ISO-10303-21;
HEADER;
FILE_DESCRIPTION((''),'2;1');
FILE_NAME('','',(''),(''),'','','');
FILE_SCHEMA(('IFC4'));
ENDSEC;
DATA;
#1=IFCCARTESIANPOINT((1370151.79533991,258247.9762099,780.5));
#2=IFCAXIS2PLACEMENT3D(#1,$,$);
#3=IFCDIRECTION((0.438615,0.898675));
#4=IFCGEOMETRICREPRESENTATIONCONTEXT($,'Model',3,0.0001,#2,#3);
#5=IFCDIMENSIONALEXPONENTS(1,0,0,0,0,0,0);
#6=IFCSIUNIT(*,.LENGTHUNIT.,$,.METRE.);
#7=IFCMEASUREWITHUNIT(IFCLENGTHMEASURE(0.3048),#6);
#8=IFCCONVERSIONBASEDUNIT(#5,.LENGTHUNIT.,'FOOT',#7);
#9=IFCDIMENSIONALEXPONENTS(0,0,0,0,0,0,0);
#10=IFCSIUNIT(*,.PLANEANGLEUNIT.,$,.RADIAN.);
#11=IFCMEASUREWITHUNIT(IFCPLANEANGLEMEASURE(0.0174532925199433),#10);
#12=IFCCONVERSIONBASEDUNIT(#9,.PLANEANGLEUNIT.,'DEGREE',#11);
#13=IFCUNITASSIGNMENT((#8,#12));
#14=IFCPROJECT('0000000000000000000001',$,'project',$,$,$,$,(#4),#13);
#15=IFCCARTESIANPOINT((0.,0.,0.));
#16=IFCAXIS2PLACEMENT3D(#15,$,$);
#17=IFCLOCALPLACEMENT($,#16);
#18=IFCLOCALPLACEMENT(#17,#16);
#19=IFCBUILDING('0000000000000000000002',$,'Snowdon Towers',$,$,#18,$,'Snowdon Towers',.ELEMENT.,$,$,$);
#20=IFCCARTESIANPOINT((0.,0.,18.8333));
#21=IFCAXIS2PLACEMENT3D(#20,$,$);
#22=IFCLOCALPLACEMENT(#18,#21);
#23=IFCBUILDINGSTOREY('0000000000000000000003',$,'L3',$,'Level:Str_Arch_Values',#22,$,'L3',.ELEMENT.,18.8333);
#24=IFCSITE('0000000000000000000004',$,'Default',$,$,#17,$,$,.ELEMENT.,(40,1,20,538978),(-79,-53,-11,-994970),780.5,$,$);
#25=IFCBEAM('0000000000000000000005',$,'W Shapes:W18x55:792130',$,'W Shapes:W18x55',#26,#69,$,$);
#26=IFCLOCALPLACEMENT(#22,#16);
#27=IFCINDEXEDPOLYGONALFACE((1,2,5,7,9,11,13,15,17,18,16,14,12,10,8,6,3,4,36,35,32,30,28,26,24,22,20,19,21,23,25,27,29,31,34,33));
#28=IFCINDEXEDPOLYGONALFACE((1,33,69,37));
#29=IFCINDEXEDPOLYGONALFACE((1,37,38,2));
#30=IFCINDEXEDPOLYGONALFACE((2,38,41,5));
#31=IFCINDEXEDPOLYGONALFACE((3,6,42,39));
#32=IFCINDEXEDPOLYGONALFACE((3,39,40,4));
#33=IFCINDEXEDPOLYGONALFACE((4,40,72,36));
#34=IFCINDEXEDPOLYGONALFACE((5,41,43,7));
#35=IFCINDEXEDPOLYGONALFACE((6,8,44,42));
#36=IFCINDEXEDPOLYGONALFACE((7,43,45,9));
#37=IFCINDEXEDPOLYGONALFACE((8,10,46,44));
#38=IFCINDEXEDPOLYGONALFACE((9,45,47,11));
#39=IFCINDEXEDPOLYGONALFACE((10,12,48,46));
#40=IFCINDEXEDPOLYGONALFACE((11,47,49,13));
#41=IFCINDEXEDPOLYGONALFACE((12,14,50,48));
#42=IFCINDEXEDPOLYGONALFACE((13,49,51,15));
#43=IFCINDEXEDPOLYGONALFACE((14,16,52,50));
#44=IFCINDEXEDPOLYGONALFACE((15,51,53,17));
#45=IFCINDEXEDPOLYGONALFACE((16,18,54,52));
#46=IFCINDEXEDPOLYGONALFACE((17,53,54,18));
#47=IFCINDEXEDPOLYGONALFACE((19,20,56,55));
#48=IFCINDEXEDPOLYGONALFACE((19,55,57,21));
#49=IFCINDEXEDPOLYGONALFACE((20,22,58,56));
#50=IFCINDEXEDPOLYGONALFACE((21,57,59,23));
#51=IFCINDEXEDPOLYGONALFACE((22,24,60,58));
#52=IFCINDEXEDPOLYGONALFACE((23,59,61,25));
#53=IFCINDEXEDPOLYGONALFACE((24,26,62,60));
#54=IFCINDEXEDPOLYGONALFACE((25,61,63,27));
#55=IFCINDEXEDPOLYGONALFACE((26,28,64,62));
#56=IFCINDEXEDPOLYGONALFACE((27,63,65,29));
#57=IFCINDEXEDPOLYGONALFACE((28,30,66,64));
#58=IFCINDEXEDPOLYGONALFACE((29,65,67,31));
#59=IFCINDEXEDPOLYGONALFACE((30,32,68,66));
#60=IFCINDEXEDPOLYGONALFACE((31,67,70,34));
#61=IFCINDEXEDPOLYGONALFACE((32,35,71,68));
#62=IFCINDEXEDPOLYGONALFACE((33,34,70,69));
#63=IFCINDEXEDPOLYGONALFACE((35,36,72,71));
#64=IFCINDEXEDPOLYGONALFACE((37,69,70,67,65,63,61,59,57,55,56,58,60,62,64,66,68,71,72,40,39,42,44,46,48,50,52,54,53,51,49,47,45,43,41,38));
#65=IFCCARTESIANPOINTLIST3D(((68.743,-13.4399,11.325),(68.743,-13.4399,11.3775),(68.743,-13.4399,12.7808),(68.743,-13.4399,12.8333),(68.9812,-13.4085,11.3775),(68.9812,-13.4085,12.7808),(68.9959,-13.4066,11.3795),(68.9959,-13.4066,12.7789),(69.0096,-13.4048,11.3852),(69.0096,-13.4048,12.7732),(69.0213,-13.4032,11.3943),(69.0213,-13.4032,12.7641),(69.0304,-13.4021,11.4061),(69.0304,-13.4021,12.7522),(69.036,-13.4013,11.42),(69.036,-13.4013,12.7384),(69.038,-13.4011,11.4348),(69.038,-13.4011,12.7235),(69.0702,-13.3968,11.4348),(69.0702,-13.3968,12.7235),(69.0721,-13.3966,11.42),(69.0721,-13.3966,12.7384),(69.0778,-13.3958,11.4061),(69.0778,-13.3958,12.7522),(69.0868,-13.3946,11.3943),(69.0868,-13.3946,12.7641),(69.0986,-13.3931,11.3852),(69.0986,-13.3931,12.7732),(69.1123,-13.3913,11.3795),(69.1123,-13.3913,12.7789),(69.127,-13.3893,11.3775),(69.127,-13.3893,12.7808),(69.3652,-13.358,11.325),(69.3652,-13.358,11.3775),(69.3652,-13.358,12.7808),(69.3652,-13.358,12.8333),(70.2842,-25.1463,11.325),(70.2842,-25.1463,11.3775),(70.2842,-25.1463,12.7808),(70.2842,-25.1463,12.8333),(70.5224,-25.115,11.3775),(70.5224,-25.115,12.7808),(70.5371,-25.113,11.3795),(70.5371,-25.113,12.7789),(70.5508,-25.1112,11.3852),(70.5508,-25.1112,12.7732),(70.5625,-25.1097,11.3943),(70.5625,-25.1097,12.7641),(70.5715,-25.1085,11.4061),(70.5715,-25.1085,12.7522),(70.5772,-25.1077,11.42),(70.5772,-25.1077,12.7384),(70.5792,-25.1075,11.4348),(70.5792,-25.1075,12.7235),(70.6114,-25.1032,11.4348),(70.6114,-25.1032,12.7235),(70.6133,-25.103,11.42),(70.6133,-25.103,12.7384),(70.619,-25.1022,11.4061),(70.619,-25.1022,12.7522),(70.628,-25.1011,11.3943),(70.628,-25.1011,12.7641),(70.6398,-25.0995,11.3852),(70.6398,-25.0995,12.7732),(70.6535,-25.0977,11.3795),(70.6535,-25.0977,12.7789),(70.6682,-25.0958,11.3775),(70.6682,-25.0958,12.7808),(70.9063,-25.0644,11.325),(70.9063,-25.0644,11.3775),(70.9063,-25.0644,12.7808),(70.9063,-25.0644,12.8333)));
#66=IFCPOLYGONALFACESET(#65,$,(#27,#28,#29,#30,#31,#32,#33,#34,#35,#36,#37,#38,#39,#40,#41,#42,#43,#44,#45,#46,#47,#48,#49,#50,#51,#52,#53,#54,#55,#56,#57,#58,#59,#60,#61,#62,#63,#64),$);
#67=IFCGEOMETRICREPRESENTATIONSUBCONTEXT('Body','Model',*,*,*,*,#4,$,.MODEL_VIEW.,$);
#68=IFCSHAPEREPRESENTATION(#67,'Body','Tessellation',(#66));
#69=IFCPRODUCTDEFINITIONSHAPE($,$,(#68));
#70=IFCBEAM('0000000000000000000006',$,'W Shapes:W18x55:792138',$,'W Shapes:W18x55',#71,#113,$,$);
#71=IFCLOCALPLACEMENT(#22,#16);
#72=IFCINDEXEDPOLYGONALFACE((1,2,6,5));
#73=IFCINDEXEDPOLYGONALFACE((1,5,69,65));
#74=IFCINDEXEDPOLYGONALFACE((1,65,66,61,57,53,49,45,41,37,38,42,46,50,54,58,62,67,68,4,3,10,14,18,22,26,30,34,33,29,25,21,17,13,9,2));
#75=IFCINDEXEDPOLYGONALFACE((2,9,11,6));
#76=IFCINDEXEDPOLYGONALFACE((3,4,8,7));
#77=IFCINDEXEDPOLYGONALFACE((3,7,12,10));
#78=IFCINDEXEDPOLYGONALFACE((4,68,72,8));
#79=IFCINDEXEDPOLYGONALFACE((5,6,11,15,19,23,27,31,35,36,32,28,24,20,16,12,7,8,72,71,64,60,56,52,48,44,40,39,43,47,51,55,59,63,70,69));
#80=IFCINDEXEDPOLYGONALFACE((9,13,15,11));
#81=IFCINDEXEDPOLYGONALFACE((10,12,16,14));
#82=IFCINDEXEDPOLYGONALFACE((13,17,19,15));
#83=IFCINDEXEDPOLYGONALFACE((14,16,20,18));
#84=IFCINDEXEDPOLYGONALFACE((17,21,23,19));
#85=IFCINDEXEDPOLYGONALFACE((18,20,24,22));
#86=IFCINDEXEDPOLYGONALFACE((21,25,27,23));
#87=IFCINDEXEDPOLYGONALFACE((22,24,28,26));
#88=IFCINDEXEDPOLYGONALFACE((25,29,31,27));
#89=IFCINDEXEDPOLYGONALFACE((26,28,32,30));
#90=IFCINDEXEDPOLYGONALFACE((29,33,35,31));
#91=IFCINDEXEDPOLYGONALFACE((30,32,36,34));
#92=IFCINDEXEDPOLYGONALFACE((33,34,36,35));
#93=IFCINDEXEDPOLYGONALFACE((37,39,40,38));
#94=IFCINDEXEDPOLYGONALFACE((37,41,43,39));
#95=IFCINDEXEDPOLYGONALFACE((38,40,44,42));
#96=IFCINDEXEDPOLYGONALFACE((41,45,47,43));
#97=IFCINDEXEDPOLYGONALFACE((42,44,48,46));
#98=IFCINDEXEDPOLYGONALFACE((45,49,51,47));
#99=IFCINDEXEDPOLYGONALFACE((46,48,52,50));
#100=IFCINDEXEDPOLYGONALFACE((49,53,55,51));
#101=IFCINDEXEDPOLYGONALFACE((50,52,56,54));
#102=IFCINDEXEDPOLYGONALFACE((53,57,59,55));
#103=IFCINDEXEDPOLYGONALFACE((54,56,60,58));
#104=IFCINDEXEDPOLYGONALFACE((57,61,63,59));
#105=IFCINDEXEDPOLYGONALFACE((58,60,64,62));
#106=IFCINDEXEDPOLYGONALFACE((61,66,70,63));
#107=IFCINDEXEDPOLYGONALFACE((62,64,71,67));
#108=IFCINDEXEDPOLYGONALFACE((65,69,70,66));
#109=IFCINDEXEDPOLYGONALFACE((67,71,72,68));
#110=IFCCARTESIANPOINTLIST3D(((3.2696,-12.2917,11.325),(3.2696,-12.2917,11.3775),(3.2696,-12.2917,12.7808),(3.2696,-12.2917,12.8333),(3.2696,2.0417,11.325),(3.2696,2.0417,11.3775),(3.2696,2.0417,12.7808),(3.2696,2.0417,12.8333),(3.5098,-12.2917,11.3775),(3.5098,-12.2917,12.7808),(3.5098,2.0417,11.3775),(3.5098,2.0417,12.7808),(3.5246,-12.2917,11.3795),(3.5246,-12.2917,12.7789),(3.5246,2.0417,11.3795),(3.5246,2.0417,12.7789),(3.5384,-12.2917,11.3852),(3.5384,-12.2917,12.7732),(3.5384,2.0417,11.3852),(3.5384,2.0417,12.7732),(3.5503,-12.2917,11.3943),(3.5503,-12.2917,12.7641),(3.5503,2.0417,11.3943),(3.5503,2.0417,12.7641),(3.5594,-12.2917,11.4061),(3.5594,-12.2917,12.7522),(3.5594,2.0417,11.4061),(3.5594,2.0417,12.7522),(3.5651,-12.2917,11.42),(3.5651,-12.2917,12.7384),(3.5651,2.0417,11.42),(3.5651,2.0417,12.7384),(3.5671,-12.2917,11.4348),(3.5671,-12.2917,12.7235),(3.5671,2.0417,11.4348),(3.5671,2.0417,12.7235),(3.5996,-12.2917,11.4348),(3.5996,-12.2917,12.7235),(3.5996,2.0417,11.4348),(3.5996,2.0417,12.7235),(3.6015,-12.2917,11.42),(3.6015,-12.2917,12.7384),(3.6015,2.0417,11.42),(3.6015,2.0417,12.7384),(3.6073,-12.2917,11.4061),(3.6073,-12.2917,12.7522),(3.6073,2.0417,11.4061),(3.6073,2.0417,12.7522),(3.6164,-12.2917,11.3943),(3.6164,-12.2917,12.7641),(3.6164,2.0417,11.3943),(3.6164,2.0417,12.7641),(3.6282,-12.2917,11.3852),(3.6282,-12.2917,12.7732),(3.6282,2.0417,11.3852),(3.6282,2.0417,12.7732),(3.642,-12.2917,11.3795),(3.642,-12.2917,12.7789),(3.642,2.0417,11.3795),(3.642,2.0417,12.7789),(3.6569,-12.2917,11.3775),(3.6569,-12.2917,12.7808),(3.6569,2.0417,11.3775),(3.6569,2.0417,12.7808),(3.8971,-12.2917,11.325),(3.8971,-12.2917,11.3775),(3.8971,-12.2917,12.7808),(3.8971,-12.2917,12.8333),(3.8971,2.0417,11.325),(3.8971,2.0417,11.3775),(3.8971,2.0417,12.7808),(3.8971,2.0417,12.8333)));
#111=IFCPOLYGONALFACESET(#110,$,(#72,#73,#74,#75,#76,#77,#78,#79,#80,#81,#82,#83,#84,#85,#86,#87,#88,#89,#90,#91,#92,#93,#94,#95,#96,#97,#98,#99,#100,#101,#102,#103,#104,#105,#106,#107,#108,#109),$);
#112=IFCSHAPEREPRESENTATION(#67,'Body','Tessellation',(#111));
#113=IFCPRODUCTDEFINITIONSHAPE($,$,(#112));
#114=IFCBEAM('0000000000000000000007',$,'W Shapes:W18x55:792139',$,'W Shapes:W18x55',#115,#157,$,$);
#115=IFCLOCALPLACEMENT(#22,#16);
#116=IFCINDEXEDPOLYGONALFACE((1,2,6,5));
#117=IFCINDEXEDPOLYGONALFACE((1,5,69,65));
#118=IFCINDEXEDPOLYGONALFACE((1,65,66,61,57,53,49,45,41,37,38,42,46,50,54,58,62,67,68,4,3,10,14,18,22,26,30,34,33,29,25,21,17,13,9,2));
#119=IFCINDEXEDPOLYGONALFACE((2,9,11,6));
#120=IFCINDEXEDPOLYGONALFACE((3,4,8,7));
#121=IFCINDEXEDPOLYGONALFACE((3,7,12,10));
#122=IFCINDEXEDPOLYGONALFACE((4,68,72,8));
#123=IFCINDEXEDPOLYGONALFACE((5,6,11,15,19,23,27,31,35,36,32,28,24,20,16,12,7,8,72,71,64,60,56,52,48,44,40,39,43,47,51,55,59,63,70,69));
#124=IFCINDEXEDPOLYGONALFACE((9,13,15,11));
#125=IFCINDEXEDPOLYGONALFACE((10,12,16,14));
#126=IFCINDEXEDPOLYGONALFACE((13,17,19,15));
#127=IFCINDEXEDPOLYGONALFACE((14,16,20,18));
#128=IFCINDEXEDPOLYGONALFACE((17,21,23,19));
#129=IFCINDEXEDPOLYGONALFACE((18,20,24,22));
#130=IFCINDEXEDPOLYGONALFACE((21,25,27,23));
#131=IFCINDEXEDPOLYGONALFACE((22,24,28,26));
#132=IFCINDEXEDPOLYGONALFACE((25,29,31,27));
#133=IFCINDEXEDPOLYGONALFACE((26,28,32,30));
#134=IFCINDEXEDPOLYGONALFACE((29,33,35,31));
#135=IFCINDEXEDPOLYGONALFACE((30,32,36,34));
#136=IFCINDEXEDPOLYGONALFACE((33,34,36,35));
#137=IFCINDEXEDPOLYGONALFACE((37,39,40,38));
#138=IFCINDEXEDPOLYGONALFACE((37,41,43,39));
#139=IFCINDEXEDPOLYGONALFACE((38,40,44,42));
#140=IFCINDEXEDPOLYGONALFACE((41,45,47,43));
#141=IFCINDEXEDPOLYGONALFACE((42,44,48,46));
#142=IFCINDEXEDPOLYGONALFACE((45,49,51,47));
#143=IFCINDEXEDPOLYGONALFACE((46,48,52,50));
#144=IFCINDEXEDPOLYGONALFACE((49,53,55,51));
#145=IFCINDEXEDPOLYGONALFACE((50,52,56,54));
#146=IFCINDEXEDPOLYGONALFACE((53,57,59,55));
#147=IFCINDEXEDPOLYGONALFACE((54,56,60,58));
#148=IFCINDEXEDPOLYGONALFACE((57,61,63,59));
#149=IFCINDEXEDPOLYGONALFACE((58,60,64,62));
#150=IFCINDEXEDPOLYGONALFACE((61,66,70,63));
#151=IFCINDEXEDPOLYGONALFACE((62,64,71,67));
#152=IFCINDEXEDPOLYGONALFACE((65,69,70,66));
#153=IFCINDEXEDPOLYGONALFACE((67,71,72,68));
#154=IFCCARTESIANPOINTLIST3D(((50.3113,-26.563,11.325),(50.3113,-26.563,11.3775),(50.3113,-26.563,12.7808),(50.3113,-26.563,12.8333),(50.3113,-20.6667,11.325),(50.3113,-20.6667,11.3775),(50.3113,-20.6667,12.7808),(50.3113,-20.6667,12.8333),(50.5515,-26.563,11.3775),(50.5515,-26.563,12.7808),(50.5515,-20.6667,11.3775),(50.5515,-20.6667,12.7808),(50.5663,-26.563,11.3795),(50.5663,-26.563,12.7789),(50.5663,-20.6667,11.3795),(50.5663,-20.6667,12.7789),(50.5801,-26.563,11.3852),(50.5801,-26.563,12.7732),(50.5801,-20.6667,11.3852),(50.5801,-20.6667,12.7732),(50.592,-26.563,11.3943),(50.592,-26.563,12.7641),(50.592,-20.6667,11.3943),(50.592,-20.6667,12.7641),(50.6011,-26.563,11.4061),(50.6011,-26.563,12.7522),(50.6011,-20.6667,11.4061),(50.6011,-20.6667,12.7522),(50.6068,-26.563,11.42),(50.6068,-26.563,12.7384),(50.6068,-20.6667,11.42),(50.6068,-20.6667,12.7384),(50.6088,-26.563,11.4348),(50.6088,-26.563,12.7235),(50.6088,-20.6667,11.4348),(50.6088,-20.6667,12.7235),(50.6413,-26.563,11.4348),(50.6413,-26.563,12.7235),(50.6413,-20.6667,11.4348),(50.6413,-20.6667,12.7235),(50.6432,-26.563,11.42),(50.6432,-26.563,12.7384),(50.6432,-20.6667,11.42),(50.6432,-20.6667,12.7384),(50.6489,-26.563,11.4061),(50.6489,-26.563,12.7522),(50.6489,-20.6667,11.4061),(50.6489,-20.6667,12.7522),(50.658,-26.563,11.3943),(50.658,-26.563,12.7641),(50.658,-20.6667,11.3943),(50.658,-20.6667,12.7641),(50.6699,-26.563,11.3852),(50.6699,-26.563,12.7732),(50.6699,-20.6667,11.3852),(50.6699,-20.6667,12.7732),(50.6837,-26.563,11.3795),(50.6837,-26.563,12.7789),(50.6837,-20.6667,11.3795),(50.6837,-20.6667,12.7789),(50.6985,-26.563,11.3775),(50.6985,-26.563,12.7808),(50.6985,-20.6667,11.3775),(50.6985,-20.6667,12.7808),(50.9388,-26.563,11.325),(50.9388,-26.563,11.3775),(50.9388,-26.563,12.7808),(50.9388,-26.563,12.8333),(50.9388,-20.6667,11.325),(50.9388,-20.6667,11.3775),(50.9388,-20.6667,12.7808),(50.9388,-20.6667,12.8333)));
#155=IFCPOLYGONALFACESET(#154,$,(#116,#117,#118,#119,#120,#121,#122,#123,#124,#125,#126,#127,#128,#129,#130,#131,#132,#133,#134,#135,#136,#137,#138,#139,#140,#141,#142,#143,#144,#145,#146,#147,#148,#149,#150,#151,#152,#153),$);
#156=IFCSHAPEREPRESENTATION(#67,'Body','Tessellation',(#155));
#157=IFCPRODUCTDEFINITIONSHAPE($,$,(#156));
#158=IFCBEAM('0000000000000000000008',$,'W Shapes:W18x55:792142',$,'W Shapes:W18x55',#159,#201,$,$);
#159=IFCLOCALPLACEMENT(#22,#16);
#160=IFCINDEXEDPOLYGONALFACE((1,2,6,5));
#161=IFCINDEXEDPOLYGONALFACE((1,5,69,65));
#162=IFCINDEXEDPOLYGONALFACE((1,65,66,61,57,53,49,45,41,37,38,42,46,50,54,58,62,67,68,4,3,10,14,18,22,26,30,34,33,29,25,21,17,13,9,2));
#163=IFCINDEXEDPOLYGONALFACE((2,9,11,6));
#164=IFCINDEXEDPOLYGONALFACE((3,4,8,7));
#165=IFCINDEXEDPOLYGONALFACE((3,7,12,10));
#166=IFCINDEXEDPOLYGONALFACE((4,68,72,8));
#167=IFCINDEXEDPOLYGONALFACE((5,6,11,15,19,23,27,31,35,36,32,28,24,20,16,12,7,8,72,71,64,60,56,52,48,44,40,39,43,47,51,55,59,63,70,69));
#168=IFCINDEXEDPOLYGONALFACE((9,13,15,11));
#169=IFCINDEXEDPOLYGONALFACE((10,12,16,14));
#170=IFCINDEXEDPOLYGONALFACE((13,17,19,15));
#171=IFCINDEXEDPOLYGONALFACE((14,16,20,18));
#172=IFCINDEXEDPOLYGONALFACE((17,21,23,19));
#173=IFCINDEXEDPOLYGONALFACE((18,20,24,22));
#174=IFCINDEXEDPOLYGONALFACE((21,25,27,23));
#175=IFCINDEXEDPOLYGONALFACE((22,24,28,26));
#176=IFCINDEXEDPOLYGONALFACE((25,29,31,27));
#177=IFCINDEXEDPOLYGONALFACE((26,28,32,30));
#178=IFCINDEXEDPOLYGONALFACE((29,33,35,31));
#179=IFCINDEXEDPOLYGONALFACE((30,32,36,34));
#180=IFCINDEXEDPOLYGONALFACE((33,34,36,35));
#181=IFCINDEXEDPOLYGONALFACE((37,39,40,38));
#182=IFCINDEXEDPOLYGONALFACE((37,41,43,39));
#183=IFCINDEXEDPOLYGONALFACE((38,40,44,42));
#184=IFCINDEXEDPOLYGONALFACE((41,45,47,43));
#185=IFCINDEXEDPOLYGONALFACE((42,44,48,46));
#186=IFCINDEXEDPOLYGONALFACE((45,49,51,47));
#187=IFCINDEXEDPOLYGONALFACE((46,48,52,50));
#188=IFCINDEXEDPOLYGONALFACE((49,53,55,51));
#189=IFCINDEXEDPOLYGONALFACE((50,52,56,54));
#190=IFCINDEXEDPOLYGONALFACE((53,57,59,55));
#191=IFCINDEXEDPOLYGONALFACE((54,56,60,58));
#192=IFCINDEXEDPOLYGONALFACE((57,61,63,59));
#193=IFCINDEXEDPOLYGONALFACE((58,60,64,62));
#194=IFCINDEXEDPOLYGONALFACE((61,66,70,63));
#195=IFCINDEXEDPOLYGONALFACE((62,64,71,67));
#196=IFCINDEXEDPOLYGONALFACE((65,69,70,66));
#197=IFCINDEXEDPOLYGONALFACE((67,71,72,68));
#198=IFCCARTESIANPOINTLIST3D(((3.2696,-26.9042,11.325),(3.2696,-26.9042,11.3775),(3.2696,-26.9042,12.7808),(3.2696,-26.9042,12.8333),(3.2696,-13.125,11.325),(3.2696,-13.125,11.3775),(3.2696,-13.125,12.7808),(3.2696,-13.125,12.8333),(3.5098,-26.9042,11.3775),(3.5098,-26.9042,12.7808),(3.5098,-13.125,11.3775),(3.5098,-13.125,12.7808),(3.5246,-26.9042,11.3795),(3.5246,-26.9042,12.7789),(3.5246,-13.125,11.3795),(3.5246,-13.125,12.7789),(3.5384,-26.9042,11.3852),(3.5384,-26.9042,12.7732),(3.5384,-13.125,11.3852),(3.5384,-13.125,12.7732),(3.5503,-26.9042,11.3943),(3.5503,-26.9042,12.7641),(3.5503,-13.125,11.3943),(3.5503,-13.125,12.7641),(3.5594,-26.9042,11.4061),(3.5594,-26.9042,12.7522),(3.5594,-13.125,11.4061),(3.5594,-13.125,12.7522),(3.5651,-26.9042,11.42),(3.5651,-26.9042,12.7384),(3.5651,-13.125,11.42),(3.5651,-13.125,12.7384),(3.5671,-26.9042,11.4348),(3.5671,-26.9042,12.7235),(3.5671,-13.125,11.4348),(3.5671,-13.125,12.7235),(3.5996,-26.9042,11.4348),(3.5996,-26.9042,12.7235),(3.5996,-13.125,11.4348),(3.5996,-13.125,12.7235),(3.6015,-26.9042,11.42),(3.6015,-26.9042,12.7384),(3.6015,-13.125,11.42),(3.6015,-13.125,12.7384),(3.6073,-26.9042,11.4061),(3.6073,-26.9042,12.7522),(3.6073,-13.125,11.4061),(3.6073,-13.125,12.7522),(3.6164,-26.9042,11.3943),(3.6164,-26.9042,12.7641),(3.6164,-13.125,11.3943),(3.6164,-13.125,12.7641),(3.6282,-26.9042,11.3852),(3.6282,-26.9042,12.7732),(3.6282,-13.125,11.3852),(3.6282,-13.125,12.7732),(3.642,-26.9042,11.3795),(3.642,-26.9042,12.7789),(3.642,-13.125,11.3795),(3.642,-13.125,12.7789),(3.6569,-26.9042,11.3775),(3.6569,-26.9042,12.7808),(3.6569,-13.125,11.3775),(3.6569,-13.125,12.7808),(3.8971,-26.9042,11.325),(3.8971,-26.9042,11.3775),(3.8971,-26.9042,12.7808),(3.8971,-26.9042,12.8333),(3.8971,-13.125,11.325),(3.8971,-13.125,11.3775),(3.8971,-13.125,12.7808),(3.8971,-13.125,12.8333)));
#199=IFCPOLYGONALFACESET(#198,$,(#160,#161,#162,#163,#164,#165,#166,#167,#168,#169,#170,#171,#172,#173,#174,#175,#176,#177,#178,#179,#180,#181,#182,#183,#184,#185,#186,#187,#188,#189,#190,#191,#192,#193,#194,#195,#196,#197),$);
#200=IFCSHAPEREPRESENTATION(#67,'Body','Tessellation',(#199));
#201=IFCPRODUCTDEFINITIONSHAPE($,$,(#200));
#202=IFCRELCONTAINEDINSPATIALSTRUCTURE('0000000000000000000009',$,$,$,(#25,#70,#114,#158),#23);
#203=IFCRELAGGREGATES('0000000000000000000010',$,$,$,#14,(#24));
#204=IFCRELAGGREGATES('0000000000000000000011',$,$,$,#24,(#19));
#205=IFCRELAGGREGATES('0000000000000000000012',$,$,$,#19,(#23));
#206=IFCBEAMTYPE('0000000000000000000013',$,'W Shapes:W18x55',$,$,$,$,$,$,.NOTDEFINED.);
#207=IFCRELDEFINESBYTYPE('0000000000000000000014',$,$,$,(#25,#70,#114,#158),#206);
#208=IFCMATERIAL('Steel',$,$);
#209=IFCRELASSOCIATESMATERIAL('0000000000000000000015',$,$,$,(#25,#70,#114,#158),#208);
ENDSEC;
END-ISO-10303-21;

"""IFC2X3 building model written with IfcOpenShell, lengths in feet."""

from ifc_helpers import new_model, entity, si_unit, converted_unit, direction, frame, frame_2d, origin, place, context, subcontext, project, spatial, i_section, extrude, material, type_object, element, save


model = new_model("IFC2X3")

# Units and contexts
model_context = context("Model", 3, precision=0.0001, world=frame((1370151.79533991, 258247.9762099, 780.5)), true_north=direction((0.438615, 0.898675)))
body_context = subcontext(model_context, "Body", "Model", "MODEL_VIEW")
ifc_project = project(units=[converted_unit("LENGTHUNIT", "FOOT", entity("IfcLengthMeasure", 0.3048), si_unit("LENGTHUNIT", "METRE"), dimensions=[1, 0, 0, 0, 0, 0, 0]), converted_unit("PLANEANGLEUNIT", "DEGREE", entity("IfcPlaneAngleMeasure", 0.0174532925199433), si_unit("PLANEANGLEUNIT", "RADIAN"), dimensions=[0, 0, 0, 0, 0, 0, 0])], contexts=[model_context])

# Site, building, storey
site_placement = place(None, origin())
site = spatial("IfcSite", under=ifc_project, at=site_placement, Name="Default", CompositionType="ELEMENT", RefLatitude=(40, 1, 20, 538978), RefLongitude=(-79, -53, -11, -994970), RefElevation=780.5)
building_placement = place(site_placement, origin())
building = spatial("IfcBuilding", under=site, at=building_placement, Name="Snowdon Towers", LongName="Snowdon Towers", CompositionType="ELEMENT")
storey_placement = place(building_placement, frame((0.0, 0.0, 18.8333)))
storey = spatial("IfcBuildingStorey", under=building, at=storey_placement, Name="L3", ObjectType="Level:Str_Arch_Values", LongName="L3", CompositionType="ELEMENT", Elevation=18.8333)

# Beams
ifc_material = material(Name="Steel")
beam_type_1 = type_object("IfcBeamType", Name="W Shapes:W18x55", PredefinedType="NOTDEFINED")
beam_1_placement = place(storey_placement, frame((68.9732, -12.7845, 12.8333), z_axis=(0.0, 0.0, 1.0), x_axis=(0.130526, -0.991445, 0.0)))
element("IfcBeam", 1, at=beam_1_placement, inside=storey, type_object=beam_type_1, material=ifc_material, Name="W Shapes:W18x55:792130", ObjectType="W Shapes:W18x55", context=body_context, shape_type="SweptSolid", body=[
    extrude(i_section(OverallWidth=0.6275, OverallDepth=1.5083, WebThickness=0.0325, FlangeThickness=0.0525, FilletRadius=0.0573, at=frame_2d((0.0, 0.0), x_axis=(0.0, 1.0))), frame((0.6198, 0.0, -0.7542), z_axis=(1.0, 0.0, 0.0), x_axis=(0.0, 0.0, -1.0)), (0.0, 0.0, 1.0), 11.8075),
])
beam_2_placement = place(storey_placement, frame((3.5833, 2.5, 12.8333), z_axis=(0.0, 0.0, 1.0), x_axis=(0.0, -1.0, 0.0)))
element("IfcBeam", 2, at=beam_2_placement, inside=storey, type_object=beam_type_1, material=ifc_material, Name="W Shapes:W18x55:792138", ObjectType="W Shapes:W18x55", context=body_context, shape_type="SweptSolid", body=[
    extrude(i_section(OverallWidth=0.6275, OverallDepth=1.5083, WebThickness=0.0325, FlangeThickness=0.0525, FilletRadius=0.0573, at=frame_2d((0.0, 0.0), x_axis=(0.0, 1.0))), frame((0.4583, 0.0, -0.7542), z_axis=(1.0, 0.0, 0.0), x_axis=(0.0, 0.0, -1.0)), (0.0, 0.0, 1.0), 14.3333),
])
beam_3_placement = place(storey_placement, frame((50.625, -20.125, 12.8333), z_axis=(0.0, 0.0, 1.0), x_axis=(0.0, -1.0, 0.0)))
element("IfcBeam", 3, at=beam_3_placement, inside=storey, type_object=beam_type_1, material=ifc_material, Name="W Shapes:W18x55:792139", ObjectType="W Shapes:W18x55", context=body_context, shape_type="SweptSolid", body=[
    extrude(i_section(OverallWidth=0.6275, OverallDepth=1.5083, WebThickness=0.0325, FlangeThickness=0.0525, FilletRadius=0.0573, at=frame_2d((0.0, 0.0), x_axis=(0.0, 1.0))), frame((0.5417, 0.0, -0.7542), z_axis=(1.0, 0.0, 0.0), x_axis=(0.0, 0.0, -1.0)), (0.0, 0.0, 1.0), 5.8964),
])
beam_4_placement = place(storey_placement, frame((3.5833, -12.7083, 12.8333), z_axis=(0.0, 0.0, 1.0), x_axis=(0.0, -1.0, 0.0)))
element("IfcBeam", 4, at=beam_4_placement, inside=storey, type_object=beam_type_1, material=ifc_material, Name="W Shapes:W18x55:792142", ObjectType="W Shapes:W18x55", context=body_context, shape_type="SweptSolid", body=[
    extrude(i_section(OverallWidth=0.6275, OverallDepth=1.5083, WebThickness=0.0325, FlangeThickness=0.0525, FilletRadius=0.0573, at=frame_2d((0.0, 0.0), x_axis=(0.0, 1.0))), frame((0.4167, 0.0, -0.7542), z_axis=(1.0, 0.0, 0.0), x_axis=(0.0, 0.0, -1.0)), (0.0, 0.0, 1.0), 13.7792),
])

save(model, "model.ifc")
